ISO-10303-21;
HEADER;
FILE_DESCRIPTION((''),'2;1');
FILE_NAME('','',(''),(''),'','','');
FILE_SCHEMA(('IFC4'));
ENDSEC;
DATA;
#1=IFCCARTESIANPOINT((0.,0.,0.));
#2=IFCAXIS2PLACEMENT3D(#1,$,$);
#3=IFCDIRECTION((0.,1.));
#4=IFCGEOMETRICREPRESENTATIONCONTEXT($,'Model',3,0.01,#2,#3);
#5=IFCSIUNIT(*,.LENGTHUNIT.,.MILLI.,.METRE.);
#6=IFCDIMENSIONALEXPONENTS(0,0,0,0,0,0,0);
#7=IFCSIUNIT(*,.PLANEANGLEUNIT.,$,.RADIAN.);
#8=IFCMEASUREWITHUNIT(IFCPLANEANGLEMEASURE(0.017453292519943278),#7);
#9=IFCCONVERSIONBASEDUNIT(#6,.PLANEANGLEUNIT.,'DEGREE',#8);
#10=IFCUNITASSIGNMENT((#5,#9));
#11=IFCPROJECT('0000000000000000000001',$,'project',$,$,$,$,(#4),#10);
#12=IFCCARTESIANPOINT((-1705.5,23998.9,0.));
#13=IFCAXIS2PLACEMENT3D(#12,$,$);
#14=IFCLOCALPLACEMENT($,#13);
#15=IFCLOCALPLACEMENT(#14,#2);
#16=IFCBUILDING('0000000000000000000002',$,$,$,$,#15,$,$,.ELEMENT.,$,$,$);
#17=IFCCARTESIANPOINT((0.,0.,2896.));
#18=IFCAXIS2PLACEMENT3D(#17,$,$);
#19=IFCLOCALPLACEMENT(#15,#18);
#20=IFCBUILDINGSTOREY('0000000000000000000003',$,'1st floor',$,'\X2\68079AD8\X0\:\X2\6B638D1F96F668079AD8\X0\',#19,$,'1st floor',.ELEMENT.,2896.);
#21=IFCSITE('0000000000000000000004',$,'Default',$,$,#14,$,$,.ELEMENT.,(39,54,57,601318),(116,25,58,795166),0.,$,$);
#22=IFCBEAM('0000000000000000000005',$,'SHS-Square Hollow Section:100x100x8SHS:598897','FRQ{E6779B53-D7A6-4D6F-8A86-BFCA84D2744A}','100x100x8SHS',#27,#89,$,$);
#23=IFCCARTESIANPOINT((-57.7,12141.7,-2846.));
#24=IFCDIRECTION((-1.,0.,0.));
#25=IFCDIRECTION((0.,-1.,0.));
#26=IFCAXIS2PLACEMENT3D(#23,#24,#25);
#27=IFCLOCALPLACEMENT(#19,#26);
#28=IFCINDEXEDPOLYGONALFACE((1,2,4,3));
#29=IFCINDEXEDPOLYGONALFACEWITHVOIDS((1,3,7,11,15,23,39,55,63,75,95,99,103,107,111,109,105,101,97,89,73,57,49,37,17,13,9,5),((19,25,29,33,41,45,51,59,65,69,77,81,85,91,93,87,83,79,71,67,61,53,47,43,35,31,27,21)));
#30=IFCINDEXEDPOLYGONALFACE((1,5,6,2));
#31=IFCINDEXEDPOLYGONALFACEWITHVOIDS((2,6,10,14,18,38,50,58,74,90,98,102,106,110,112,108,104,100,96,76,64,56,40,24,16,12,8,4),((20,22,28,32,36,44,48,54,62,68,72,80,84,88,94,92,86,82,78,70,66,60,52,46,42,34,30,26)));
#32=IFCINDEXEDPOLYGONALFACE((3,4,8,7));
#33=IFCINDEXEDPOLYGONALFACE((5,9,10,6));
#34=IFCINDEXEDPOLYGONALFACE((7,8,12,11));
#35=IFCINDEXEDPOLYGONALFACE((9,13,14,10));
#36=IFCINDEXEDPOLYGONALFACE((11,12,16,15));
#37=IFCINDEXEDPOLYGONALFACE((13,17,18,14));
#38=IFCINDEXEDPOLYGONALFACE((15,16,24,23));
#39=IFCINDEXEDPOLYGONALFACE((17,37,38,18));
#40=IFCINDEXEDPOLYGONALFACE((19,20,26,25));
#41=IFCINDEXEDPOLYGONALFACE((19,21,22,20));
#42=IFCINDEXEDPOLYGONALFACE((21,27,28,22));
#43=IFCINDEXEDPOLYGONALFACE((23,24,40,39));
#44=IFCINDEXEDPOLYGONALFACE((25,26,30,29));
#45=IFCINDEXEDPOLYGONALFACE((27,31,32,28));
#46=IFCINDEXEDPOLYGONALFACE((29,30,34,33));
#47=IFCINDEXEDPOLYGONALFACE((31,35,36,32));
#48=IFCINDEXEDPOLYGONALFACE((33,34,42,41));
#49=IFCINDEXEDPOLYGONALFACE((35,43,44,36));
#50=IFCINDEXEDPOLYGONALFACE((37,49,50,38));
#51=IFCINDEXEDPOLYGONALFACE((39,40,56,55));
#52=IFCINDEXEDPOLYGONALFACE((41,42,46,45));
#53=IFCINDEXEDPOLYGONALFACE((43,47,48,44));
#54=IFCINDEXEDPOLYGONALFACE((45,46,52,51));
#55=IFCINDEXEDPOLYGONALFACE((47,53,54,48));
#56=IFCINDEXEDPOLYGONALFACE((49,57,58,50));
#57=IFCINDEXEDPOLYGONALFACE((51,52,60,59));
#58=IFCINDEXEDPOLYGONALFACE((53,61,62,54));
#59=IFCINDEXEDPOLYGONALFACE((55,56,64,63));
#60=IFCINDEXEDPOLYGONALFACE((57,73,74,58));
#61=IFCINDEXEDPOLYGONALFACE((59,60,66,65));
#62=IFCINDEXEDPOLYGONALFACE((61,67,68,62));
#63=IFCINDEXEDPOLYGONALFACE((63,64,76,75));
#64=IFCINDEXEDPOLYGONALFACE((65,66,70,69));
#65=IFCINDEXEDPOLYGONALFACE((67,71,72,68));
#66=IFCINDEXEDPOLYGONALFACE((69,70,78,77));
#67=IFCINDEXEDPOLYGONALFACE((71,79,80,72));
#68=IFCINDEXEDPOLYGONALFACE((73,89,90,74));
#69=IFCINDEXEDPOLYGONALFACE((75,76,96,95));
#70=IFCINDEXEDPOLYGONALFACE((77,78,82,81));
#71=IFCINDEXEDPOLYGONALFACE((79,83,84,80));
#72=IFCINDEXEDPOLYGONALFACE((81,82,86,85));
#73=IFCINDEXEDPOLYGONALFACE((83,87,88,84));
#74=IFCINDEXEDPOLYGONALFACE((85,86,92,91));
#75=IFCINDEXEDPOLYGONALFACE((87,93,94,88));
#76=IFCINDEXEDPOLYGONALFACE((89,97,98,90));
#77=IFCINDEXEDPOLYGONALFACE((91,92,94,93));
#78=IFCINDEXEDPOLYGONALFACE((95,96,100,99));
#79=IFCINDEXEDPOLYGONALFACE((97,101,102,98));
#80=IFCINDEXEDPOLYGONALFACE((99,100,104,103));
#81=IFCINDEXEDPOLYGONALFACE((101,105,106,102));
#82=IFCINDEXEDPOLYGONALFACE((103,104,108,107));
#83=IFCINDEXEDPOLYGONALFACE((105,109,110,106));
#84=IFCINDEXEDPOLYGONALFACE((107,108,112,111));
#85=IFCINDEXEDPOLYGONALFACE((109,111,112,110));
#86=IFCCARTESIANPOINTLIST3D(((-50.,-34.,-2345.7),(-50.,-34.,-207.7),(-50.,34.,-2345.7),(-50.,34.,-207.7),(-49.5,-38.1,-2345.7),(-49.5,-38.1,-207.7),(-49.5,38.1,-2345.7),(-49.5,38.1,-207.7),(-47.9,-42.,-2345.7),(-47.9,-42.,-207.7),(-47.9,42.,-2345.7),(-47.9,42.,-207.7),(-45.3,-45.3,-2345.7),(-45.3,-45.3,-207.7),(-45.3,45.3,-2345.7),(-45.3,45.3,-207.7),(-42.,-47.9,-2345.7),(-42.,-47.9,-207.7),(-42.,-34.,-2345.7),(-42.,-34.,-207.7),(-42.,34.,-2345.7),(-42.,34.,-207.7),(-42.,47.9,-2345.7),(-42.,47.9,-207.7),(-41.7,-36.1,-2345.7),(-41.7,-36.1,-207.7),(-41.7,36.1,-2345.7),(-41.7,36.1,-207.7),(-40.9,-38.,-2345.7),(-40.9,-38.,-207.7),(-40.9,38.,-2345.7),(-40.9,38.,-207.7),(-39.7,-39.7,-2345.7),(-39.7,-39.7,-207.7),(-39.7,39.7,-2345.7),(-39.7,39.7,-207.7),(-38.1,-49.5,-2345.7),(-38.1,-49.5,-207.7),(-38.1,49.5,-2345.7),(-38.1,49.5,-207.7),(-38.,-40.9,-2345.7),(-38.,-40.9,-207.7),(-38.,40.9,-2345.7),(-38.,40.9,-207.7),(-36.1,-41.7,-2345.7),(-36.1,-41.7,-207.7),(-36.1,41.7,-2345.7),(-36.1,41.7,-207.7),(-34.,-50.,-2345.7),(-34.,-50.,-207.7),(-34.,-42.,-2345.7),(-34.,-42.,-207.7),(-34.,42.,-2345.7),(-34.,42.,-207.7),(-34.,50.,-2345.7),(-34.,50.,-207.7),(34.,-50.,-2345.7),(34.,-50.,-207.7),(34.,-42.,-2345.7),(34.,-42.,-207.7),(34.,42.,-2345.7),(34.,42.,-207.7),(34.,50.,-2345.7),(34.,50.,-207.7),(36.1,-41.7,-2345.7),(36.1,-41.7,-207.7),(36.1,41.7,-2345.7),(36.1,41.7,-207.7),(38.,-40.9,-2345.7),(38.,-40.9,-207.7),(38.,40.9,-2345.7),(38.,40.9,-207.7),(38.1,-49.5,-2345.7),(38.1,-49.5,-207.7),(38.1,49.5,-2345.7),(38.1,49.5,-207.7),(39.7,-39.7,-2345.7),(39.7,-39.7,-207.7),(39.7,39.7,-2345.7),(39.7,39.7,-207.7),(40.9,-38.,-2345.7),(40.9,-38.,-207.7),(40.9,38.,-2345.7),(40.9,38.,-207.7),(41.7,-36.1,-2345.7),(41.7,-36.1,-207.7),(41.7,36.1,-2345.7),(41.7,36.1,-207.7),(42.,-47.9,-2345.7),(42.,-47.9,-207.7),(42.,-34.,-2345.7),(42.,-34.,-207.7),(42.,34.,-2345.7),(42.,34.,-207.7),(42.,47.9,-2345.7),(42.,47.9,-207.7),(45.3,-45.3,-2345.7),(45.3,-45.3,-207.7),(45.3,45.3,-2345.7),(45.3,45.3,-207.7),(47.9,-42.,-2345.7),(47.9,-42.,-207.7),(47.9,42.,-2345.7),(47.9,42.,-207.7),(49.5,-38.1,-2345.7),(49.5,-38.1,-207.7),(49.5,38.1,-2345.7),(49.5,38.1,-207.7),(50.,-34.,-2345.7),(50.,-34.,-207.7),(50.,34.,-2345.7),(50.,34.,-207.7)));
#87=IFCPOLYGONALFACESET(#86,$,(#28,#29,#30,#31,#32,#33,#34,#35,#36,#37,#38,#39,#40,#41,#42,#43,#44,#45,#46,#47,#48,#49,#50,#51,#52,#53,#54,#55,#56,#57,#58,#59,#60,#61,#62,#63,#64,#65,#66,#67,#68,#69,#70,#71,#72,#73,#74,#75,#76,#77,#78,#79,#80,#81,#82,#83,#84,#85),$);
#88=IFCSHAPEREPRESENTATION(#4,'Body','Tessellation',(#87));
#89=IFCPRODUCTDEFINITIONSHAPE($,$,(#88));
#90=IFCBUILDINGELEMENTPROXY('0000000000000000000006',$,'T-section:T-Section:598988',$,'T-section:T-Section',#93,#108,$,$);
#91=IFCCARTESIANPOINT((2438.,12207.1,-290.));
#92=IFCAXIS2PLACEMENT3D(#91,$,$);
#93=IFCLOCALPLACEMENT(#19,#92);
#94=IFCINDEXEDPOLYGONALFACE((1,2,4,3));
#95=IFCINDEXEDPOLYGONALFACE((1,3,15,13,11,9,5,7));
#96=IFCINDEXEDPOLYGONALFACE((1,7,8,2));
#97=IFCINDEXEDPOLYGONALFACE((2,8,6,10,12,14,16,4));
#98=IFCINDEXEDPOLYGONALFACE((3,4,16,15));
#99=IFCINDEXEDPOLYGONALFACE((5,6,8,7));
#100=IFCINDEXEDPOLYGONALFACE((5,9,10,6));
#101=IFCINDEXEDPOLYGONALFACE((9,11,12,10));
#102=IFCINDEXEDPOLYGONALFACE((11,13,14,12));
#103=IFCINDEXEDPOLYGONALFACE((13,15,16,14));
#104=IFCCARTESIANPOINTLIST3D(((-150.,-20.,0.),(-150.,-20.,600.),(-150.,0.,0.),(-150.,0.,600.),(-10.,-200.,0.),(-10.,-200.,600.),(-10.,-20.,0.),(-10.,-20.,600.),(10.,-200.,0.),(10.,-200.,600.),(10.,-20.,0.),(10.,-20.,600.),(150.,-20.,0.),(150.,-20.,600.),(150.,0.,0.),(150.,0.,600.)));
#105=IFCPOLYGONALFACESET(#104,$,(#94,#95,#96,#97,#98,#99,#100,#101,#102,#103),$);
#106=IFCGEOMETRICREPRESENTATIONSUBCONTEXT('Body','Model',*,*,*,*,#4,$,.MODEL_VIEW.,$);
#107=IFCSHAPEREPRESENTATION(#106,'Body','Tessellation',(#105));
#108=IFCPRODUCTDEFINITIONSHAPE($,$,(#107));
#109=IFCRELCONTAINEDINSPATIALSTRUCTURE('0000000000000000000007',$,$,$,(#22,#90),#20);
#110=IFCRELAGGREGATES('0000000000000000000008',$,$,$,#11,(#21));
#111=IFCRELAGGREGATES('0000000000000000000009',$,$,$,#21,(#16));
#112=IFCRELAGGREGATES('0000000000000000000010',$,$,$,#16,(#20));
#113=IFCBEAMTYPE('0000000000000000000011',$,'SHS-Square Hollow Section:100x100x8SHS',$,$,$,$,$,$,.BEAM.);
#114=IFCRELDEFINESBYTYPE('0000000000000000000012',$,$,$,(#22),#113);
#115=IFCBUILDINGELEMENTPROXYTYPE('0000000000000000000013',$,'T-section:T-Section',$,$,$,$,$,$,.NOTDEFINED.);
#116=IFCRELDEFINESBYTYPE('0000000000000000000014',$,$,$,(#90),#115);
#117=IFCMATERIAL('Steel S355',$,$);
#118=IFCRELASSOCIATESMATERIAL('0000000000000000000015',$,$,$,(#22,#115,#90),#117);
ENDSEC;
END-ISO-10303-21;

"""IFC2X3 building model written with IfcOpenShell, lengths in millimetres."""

from ifc_helpers import new_model, entity, si_unit, converted_unit, direction, frame, origin, origin_2d, place, context, subcontext, project, spatial, polyline, hollow_rectangle, outline, extrude, clip, halfspace, source, transform, mapped, material, type_object, type_shapes, element, save


model = new_model("IFC2X3")

# Units and contexts
model_context = context("Model", 3, precision=0.01, world=origin(), true_north=direction((0.0, 1.0)))
body_context = subcontext(model_context, "Body", "Model", "MODEL_VIEW")
ifc_project = project(units=[si_unit("LENGTHUNIT", "METRE", prefix="MILLI"), converted_unit("PLANEANGLEUNIT", "DEGREE", entity("IfcPlaneAngleMeasure", 0.017453292519943278), si_unit("PLANEANGLEUNIT", "RADIAN"), dimensions=[0, 0, 0, 0, 0, 0, 0])], contexts=[model_context])

# Site, building, storey
site_placement = place(None, frame((-1705.5, 23998.9, 0.0)))
site = spatial("IfcSite", under=ifc_project, at=site_placement, Name="Default", CompositionType="ELEMENT", RefLatitude=(39, 54, 57, 601318), RefLongitude=(116, 25, 58, 795166), RefElevation=0.0)
building_placement = place(site_placement, origin())
building = spatial("IfcBuilding", under=site, at=building_placement, CompositionType="ELEMENT")
storey_placement = place(building_placement, frame((0.0, 0.0, 2896.0)))
storey = spatial("IfcBuildingStorey", under=building, at=storey_placement, Name="1st floor", ObjectType="标高:正负零标高", LongName="1st floor", CompositionType="ELEMENT", Elevation=2896.0)

# Shared definitions
ifc_material_1 = material(Name="Steel S355")

# Beam
beam_type_1 = type_object("IfcBeamType", Name="SHS-Square Hollow Section:100x100x8SHS", PredefinedType="BEAM")
beam_1_placement = place(storey_placement, frame((-57.7, 12141.7, -2846.0), z_axis=(-1.0, 0.0, 0.0), x_axis=(0.0, -1.0, 0.0)))
element("IfcBeam", 1, at=beam_1_placement, inside=storey, type_object=beam_type_1, material=ifc_material_1, Name="SHS-Square Hollow Section:100x100x8SHS:598897", Description="FRQ{E6779B53-D7A6-4D6F-8A86-BFCA84D2744A}", ObjectType="100x100x8SHS", context=model_context, shape_type="Clipping", body=[
    clip(clip(extrude(hollow_rectangle(XDim=100.0, YDim=100.0, WallThickness=8.0, InnerFilletRadius=8.0, OuterFilletRadius=16.0, at=origin_2d()), origin(), (0.0, 0.0, -1.0), 2551.4), halfspace(frame((12141.7, -50.0, -207.7), z_axis=(0.0, 0.0, -1.0), x_axis=(-1.0, 0.0, 0.0)), True)), halfspace(frame((12141.7, -50.0, -2345.7), z_axis=(0.0, 0.0, 1.0), x_axis=(1.0, 0.0, 0.0)), True)),
])

# Building element proxy
building_element_proxy_type_1 = type_object("IfcBuildingElementProxyType", Name="T-section:T-Section", PredefinedType="NOTDEFINED", material=ifc_material_1)
shared_shape_1 = source(origin(), body_context, "Body", "SweptSolid", [
    extrude(outline(polyline([(-10.0, -140.0), (10.0, -140.0), (10.0, 40.0), (150.0, 40.0), (150.0, 60.0), (-150.0, 60.0), (-150.0, 40.0), (-10.0, 40.0), (-10.0, -140.0)])), frame((0.0, -60.0, 0.0)), (0.0, 0.0, 1.0), 600.0),
])
type_shapes(building_element_proxy_type_1, [shared_shape_1])
proxy_placement = place(storey_placement, frame((2438.0, 12207.1, -290.0)))
element("IfcBuildingElementProxy", 2, at=proxy_placement, inside=storey, type_object=building_element_proxy_type_1, material=ifc_material_1, Name="T-section:T-Section:598988", ObjectType="T-section:T-Section", context=body_context, shape_type="MappedRepresentation", body=[
    mapped(shared_shape_1, transform((0.0, 0.0, 0.0), scale=1.0)),
])

save(model, "model.ifc")
